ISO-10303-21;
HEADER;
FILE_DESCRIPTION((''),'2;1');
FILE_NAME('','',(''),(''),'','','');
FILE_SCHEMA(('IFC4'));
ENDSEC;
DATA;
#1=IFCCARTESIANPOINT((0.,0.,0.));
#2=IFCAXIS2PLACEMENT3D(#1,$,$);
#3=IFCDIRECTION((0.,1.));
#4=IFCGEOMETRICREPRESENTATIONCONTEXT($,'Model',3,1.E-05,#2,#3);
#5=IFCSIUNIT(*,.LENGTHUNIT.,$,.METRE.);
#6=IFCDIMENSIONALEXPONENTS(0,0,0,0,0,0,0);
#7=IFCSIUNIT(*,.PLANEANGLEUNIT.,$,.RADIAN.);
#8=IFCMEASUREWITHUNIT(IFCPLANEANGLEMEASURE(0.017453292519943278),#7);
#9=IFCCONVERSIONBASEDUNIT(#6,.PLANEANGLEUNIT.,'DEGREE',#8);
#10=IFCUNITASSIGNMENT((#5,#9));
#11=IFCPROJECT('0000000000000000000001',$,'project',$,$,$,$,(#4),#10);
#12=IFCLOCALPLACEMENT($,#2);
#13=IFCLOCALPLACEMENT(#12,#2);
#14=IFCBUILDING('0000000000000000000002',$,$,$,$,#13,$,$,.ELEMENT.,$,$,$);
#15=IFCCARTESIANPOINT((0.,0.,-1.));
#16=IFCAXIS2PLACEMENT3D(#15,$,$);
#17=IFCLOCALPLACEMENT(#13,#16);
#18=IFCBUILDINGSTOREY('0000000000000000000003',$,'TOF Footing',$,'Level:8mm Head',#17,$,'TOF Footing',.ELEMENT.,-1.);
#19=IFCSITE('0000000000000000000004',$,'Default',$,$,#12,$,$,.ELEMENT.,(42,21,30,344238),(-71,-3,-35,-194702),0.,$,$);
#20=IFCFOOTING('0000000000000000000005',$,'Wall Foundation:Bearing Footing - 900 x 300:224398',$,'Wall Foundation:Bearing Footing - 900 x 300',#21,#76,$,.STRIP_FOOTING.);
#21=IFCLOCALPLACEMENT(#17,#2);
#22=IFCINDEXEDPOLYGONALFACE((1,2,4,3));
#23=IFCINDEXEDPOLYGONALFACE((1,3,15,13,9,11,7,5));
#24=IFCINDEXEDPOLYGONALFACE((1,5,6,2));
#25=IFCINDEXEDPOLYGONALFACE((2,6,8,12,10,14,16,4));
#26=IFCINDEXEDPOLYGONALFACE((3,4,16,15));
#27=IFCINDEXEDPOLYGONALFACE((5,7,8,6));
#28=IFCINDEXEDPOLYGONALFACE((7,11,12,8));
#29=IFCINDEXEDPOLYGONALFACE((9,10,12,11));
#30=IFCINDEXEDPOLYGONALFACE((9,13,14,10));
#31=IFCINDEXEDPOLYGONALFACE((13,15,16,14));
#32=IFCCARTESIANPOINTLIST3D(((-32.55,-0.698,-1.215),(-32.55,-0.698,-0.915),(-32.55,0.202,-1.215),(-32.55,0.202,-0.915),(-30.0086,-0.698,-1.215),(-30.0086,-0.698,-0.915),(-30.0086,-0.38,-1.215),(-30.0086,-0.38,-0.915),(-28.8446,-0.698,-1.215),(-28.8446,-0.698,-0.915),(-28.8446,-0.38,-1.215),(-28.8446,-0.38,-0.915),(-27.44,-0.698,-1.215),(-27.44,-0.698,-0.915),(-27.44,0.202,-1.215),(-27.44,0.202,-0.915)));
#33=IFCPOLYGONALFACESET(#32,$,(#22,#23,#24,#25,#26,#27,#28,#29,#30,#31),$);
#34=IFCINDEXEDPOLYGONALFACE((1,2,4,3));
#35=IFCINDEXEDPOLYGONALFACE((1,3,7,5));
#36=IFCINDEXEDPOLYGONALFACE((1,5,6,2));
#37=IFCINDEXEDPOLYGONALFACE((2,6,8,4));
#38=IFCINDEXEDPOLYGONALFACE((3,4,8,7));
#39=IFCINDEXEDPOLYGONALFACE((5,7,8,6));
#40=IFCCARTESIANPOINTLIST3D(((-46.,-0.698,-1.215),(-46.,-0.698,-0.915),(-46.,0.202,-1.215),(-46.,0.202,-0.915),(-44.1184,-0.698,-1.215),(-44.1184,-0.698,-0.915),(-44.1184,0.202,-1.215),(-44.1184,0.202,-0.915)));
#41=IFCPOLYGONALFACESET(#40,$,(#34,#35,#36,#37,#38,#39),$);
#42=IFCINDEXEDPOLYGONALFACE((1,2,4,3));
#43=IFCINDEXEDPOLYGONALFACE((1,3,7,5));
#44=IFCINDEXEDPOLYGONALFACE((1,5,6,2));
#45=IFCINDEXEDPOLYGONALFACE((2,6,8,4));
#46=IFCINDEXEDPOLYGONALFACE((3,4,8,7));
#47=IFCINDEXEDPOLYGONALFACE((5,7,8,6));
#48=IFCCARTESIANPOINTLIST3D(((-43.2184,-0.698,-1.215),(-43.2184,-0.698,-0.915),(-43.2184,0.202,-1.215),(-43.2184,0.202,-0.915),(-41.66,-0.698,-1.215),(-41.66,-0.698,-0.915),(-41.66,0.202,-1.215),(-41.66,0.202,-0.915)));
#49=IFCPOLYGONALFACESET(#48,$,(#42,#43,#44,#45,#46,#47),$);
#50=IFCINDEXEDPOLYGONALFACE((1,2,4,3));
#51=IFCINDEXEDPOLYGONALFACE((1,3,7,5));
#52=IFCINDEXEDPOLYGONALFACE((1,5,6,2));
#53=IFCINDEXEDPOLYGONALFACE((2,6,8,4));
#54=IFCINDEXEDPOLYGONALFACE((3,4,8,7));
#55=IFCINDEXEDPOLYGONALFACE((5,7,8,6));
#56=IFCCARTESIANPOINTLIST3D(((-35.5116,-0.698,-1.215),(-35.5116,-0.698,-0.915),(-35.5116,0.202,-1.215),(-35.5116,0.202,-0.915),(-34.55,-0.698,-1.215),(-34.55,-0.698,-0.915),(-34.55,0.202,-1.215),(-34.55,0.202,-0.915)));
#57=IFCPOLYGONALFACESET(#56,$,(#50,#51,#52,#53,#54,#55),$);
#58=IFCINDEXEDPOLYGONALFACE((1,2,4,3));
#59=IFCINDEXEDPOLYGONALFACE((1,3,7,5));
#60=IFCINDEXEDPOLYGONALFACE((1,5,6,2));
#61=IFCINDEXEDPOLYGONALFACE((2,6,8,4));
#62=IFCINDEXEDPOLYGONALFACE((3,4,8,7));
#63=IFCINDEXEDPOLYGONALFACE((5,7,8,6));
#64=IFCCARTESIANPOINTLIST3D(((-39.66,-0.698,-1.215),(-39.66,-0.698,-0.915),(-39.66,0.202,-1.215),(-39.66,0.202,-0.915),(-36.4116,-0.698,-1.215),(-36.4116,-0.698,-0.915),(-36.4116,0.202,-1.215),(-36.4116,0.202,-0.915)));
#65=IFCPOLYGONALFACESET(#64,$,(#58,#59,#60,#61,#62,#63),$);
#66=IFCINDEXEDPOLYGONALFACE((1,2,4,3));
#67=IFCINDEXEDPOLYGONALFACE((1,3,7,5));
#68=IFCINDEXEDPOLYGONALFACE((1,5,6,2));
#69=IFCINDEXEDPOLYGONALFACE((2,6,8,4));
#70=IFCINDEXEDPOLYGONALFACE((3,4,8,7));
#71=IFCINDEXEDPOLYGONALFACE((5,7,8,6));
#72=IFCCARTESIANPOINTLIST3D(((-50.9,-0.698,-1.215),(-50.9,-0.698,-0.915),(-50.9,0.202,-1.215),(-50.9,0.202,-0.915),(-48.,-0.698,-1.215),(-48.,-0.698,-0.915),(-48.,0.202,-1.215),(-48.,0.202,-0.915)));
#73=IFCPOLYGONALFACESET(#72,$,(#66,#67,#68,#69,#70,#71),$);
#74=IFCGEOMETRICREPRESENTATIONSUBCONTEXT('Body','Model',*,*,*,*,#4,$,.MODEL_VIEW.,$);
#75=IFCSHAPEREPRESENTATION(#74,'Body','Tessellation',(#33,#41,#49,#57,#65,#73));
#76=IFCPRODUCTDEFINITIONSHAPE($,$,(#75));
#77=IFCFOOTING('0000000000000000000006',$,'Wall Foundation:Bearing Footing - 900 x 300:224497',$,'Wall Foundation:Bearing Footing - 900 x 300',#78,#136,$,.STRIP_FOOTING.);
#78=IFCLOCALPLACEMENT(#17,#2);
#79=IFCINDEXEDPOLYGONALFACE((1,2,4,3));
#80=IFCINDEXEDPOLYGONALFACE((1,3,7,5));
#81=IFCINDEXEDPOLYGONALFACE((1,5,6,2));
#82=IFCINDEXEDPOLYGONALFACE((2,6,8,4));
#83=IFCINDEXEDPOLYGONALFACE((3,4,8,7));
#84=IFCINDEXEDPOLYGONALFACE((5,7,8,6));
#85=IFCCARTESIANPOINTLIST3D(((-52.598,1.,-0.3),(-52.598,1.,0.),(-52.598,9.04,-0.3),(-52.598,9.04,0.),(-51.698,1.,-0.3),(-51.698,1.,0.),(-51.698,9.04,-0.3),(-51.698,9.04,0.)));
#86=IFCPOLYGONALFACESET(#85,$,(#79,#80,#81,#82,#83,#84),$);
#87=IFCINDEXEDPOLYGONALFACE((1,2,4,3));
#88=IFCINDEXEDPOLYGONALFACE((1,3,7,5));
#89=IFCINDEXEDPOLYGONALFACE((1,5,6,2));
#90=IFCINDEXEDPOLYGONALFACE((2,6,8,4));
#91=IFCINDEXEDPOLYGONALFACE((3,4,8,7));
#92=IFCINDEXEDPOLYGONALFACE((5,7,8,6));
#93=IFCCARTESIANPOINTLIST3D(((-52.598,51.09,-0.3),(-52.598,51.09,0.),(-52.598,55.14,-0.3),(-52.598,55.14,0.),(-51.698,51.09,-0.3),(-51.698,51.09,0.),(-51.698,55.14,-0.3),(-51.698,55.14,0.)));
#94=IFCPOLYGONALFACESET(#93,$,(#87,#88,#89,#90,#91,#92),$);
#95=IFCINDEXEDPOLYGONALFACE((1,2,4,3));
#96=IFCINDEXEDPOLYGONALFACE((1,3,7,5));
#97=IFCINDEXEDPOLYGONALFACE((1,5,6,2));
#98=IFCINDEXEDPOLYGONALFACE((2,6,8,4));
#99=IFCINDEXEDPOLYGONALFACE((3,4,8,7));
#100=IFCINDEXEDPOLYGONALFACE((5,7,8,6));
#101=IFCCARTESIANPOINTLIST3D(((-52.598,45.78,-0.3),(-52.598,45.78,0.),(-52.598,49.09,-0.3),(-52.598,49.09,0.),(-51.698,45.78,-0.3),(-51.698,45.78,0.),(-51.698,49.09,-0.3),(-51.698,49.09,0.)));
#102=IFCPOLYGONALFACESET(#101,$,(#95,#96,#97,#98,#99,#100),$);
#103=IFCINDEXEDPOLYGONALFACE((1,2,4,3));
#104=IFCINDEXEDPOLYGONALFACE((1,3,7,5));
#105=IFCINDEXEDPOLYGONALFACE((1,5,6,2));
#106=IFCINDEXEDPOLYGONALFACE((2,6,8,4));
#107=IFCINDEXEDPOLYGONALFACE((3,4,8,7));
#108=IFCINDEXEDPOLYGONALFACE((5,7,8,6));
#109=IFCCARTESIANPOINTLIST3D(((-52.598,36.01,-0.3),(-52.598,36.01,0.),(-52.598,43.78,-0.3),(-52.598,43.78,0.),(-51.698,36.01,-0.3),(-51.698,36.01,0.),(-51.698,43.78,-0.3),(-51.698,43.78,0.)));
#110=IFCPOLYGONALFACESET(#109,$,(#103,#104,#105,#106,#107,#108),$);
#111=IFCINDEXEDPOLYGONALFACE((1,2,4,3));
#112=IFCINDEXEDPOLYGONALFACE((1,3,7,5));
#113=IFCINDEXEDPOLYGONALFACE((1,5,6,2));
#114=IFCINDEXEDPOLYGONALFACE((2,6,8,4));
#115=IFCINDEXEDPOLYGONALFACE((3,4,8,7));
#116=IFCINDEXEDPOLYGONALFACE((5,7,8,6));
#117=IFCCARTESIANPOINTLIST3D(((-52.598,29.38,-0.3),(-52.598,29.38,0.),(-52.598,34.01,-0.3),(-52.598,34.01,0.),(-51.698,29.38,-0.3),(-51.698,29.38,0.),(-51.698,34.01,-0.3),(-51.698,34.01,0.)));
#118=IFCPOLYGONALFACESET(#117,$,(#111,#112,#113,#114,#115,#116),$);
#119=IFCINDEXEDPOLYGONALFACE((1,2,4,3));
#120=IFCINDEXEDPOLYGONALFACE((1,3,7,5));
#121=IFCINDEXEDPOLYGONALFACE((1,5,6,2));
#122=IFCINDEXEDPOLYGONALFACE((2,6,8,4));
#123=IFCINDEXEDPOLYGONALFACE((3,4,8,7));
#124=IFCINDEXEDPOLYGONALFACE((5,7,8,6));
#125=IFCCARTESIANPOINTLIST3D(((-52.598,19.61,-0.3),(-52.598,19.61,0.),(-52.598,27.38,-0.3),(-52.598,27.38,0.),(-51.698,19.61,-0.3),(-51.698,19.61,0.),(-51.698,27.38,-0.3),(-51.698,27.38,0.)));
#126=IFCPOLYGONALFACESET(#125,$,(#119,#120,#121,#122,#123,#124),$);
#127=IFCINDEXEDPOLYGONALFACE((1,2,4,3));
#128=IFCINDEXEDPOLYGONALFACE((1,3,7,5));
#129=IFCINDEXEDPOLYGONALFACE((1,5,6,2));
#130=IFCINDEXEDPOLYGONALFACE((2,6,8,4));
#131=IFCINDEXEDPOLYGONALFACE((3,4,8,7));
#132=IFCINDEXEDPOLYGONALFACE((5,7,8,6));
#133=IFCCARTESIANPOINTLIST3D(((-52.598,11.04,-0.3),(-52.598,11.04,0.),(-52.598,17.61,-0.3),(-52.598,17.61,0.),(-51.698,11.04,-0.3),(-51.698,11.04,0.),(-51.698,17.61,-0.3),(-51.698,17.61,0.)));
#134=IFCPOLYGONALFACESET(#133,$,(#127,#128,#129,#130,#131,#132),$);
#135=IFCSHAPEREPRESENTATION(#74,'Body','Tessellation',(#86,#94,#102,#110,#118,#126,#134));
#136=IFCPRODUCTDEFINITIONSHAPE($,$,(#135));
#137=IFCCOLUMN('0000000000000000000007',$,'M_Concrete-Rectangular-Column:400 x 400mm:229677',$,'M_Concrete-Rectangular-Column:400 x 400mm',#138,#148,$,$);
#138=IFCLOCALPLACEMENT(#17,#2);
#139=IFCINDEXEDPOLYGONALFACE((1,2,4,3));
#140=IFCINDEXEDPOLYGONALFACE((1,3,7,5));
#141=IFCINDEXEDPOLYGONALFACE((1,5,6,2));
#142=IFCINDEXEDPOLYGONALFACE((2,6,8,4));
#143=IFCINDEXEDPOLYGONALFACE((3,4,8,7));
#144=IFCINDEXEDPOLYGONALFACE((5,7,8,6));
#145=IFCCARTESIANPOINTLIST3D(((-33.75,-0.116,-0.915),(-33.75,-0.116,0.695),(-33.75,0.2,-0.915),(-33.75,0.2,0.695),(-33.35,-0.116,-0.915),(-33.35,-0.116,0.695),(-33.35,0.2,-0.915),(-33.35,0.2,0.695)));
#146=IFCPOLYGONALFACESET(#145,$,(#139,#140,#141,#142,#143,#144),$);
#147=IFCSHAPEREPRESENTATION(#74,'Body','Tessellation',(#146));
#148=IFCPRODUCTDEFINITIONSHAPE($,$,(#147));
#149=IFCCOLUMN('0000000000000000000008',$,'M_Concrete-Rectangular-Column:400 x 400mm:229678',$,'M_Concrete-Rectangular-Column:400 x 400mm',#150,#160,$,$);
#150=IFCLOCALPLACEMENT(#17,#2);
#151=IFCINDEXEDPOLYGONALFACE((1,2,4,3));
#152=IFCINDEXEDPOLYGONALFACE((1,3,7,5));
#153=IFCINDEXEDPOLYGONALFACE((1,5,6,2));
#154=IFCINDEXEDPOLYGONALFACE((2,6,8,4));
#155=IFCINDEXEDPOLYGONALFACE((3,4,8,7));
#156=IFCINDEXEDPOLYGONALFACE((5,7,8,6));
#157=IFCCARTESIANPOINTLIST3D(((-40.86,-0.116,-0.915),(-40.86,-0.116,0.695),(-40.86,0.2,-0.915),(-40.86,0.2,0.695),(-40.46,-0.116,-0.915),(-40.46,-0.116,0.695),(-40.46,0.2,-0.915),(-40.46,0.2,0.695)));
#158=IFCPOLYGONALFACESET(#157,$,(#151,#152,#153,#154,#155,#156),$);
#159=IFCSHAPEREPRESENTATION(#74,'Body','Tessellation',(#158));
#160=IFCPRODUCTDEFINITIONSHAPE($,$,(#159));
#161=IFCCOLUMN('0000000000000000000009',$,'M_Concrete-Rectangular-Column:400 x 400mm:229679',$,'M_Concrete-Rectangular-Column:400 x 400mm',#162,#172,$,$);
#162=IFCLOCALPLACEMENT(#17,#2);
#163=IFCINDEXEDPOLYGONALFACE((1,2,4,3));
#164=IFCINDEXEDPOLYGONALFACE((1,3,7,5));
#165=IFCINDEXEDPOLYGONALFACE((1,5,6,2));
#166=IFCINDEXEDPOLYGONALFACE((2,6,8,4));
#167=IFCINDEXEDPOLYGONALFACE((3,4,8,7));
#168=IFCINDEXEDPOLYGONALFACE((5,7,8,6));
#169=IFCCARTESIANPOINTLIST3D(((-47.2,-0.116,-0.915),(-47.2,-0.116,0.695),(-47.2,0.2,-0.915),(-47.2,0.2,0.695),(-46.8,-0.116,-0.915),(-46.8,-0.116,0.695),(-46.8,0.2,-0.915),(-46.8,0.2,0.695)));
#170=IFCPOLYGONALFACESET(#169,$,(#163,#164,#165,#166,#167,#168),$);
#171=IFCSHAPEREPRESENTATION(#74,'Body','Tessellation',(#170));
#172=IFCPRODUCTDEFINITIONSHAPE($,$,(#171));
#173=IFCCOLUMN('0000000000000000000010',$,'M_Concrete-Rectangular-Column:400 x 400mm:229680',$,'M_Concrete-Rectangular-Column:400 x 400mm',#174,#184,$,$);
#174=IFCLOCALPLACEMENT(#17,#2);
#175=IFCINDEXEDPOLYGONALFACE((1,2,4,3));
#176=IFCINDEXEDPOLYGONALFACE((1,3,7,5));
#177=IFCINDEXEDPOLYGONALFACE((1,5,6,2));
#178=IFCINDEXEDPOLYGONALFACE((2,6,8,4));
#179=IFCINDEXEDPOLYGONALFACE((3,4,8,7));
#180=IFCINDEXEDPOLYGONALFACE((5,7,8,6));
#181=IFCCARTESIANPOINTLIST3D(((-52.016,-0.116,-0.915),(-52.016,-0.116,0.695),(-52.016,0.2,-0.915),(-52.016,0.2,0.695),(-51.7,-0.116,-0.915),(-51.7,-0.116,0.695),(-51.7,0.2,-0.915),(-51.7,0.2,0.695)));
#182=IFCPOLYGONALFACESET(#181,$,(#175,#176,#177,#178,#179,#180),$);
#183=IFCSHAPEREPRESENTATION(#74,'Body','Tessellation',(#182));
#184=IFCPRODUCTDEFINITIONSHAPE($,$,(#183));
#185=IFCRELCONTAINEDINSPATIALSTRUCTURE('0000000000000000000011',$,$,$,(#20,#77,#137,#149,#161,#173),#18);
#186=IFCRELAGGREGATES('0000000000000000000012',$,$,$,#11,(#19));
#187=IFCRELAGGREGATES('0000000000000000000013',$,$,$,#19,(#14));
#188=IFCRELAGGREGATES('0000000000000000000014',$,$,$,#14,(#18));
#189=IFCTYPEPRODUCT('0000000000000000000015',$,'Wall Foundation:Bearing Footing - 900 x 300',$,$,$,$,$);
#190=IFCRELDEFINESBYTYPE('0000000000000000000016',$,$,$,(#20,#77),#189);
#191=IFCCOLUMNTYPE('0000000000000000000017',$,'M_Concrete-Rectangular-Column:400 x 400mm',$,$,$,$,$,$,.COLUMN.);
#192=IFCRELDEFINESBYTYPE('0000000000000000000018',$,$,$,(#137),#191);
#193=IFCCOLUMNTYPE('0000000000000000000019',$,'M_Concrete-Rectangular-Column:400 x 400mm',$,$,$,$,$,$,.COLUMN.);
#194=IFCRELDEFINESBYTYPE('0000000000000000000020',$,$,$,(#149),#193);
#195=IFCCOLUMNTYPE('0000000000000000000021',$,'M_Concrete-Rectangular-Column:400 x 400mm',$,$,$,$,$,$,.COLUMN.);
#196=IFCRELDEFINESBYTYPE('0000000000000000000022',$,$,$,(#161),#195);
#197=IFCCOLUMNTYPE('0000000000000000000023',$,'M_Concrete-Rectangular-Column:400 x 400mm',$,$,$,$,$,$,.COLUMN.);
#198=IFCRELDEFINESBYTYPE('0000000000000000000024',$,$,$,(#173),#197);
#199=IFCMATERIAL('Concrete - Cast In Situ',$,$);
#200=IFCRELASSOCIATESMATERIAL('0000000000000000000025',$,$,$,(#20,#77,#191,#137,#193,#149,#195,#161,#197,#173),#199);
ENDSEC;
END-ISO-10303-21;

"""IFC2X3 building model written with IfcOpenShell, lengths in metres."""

from ifc_helpers import new_model, entity, si_unit, converted_unit, direction, frame, frame_2d, origin, origin_2d_with_axis, place, context, subcontext, project, spatial, polyline, rectangle, outline, extrude, source, transform, mapped, material, type_object, type_shapes, element, save


model = new_model("IFC2X3")

# Units and contexts
model_context = context("Model", 3, precision=1e-05, world=origin(), true_north=direction((0.0, 1.0)))
body_context = subcontext(model_context, "Body", "Model", "MODEL_VIEW")
ifc_project = project(units=[si_unit("LENGTHUNIT", "METRE"), converted_unit("PLANEANGLEUNIT", "DEGREE", entity("IfcPlaneAngleMeasure", 0.017453292519943278), si_unit("PLANEANGLEUNIT", "RADIAN"), dimensions=[0, 0, 0, 0, 0, 0, 0])], contexts=[model_context])

# Site, building, storey
site_placement = place(None, origin())
site = spatial("IfcSite", under=ifc_project, at=site_placement, Name="Default", CompositionType="ELEMENT", RefLatitude=(42, 21, 30, 344238), RefLongitude=(-71, -3, -35, -194702), RefElevation=0.0)
building_placement = place(site_placement, origin())
building = spatial("IfcBuilding", under=site, at=building_placement, CompositionType="ELEMENT")
storey_placement = place(building_placement, frame((0.0, 0.0, -1.0)))
storey = spatial("IfcBuildingStorey", under=building, at=storey_placement, Name="TOF Footing", ObjectType="Level:8mm Head", LongName="TOF Footing", CompositionType="ELEMENT", Elevation=-1.0)

# Footings
ifc_material = material(Name="Concrete - Cast In Situ")
type_product_1 = type_object("IfcTypeProduct", Name="Wall Foundation:Bearing Footing - 900 x 300")
footing_1_placement = place(storey_placement, origin())
element("IfcFooting", 1, at=footing_1_placement, inside=storey, type_object=type_product_1, material=ifc_material, Name="Wall Foundation:Bearing Footing - 900 x 300:224398", ObjectType="Wall Foundation:Bearing Footing - 900 x 300", PredefinedType="STRIP_FOOTING", context=body_context, shape_type="SweptSolid", body=[
    extrude(outline(polyline([(-2.2708, -0.5955), (2.8392, -0.5955), (2.8392, 0.3045), (0.2978, 0.3045), (0.2978, -0.0135), (-0.8662, -0.0135), (-0.8662, 0.3045), (-2.2708, 0.3045), (-2.2708, -0.5955)])), frame((-29.7108, -0.3935, -1.215), z_axis=(0.0, 0.0, 1.0), x_axis=(-1.0, 0.0, 0.0)), (0.0, 0.0, 1.0), 0.3),
    extrude(rectangle(XDim=1.8816, YDim=0.9, at=frame_2d((0.0, 0.0), x_axis=(1.0, 0.0))), frame((-45.0592, -0.248, -1.215), z_axis=(0.0, 0.0, 1.0), x_axis=(-1.0, 0.0, 0.0)), (0.0, 0.0, 1.0), 0.3),
    extrude(rectangle(XDim=1.5584, YDim=0.9, at=origin_2d_with_axis()), frame((-42.4392, -0.248, -1.215)), (0.0, 0.0, 1.0), 0.3),
    extrude(rectangle(XDim=0.9616, YDim=0.9, at=frame_2d((0.0, 0.0), x_axis=(1.0, 0.0))), frame((-35.0308, -0.248, -1.215)), (0.0, 0.0, 1.0), 0.3),
    extrude(rectangle(XDim=3.2484, YDim=0.9, at=frame_2d((0.0, 0.0), x_axis=(1.0, 0.0))), frame((-38.0358, -0.248, -1.215), z_axis=(0.0, 0.0, 1.0), x_axis=(-1.0, 0.0, 0.0)), (0.0, 0.0, 1.0), 0.3),
    extrude(rectangle(XDim=2.9, YDim=0.9, at=frame_2d((0.0, 0.0), x_axis=(1.0, 0.0))), frame((-49.45, -0.248, -1.215)), (0.0, 0.0, 1.0), 0.3),
])
footing_2_placement = place(storey_placement, origin())
element("IfcFooting", 2, at=footing_2_placement, inside=storey, type_object=type_product_1, material=ifc_material, Name="Wall Foundation:Bearing Footing - 900 x 300:224497", ObjectType="Wall Foundation:Bearing Footing - 900 x 300", PredefinedType="STRIP_FOOTING", context=body_context, shape_type="SweptSolid", body=[
    extrude(rectangle(XDim=8.04, YDim=0.9, at=frame_2d((0.0, 0.0), x_axis=(1.0, 0.0))), frame((-52.148, 5.02, -0.3), z_axis=(0.0, 0.0, 1.0), x_axis=(0.0, 1.0, 0.0)), (0.0, 0.0, 1.0), 0.3),
    extrude(rectangle(XDim=4.05, YDim=0.9, at=frame_2d((0.0, 0.0), x_axis=(1.0, 0.0))), frame((-52.148, 53.115, -0.3), z_axis=(0.0, 0.0, 1.0), x_axis=(0.0, -1.0, 0.0)), (0.0, 0.0, 1.0), 0.3),
    extrude(rectangle(XDim=3.31, YDim=0.9, at=frame_2d((0.0, 0.0), x_axis=(1.0, 0.0))), frame((-52.148, 47.435, -0.3), z_axis=(0.0, 0.0, 1.0), x_axis=(0.0, -1.0, 0.0)), (0.0, 0.0, 1.0), 0.3),
    extrude(rectangle(XDim=7.77, YDim=0.9, at=frame_2d((0.0, 0.0), x_axis=(1.0, 0.0))), frame((-52.148, 39.895, -0.3), z_axis=(0.0, 0.0, 1.0), x_axis=(0.0, -1.0, 0.0)), (0.0, 0.0, 1.0), 0.3),
    extrude(rectangle(XDim=4.63, YDim=0.9, at=frame_2d((0.0, 0.0), x_axis=(1.0, 0.0))), frame((-52.148, 31.695, -0.3), z_axis=(0.0, 0.0, 1.0), x_axis=(0.0, -1.0, 0.0)), (0.0, 0.0, 1.0), 0.3),
    extrude(rectangle(XDim=7.77, YDim=0.9, at=frame_2d((0.0, 0.0), x_axis=(1.0, 0.0))), frame((-52.148, 23.495, -0.3), z_axis=(0.0, 0.0, 1.0), x_axis=(0.0, -1.0, 0.0)), (0.0, 0.0, 1.0), 0.3),
    extrude(rectangle(XDim=6.57, YDim=0.9, at=frame_2d((0.0, 0.0), x_axis=(1.0, 0.0))), frame((-52.148, 14.325, -0.3), z_axis=(0.0, 0.0, 1.0), x_axis=(0.0, -1.0, 0.0)), (0.0, 0.0, 1.0), 0.3),
])

# Columns
column_type_1 = type_object("IfcColumnType", Name="M_Concrete-Rectangular-Column:400 x 400mm", PredefinedType="COLUMN", material=ifc_material)
shared_shape_1 = source(origin(), body_context, "Body", "SweptSolid", [
    extrude(rectangle(XDim=0.316, YDim=0.4, at=frame_2d((0.0, 0.0), x_axis=(1.0, 0.0))), frame((-33.55, 0.042, -1.915), z_axis=(0.0, 0.0, 1.0), x_axis=(0.0, -1.0, 0.0)), (0.0, 0.0, 1.0), 1.61),
])
type_shapes(column_type_1, [shared_shape_1])
column_1_placement = place(storey_placement, frame((0.0, 0.0, 1.0)))
element("IfcColumn", 3, at=column_1_placement, inside=storey, type_object=column_type_1, material=ifc_material, Name="M_Concrete-Rectangular-Column:400 x 400mm:229677", ObjectType="M_Concrete-Rectangular-Column:400 x 400mm", context=body_context, shape_type="MappedRepresentation", body=[
    mapped(shared_shape_1, transform((0.0, 0.0, 0.0), scale=1.0)),
])
column_type_2 = type_object("IfcColumnType", Name="M_Concrete-Rectangular-Column:400 x 400mm", PredefinedType="COLUMN", material=ifc_material)
shared_shape_2 = source(origin(), body_context, "Body", "SweptSolid", [
    extrude(rectangle(XDim=0.316, YDim=0.4, at=frame_2d((0.0, 0.0), x_axis=(1.0, 0.0))), frame((-40.66, 0.042, -1.915), z_axis=(0.0, 0.0, 1.0), x_axis=(0.0, -1.0, 0.0)), (0.0, 0.0, 1.0), 1.61),
])
type_shapes(column_type_2, [shared_shape_2])
column_2_placement = place(storey_placement, frame((0.0, 0.0, 1.0)))
element("IfcColumn", 4, at=column_2_placement, inside=storey, type_object=column_type_2, material=ifc_material, Name="M_Concrete-Rectangular-Column:400 x 400mm:229678", ObjectType="M_Concrete-Rectangular-Column:400 x 400mm", context=body_context, shape_type="MappedRepresentation", body=[
    mapped(shared_shape_2, transform((0.0, 0.0, 0.0), scale=1.0)),
])
column_type_3 = type_object("IfcColumnType", Name="M_Concrete-Rectangular-Column:400 x 400mm", PredefinedType="COLUMN", material=ifc_material)
shared_shape_3 = source(origin(), body_context, "Body", "SweptSolid", [
    extrude(rectangle(XDim=0.316, YDim=0.4, at=frame_2d((0.0, 0.0), x_axis=(1.0, 0.0))), frame((-47.0, 0.042, -1.915), z_axis=(0.0, 0.0, 1.0), x_axis=(0.0, -1.0, 0.0)), (0.0, 0.0, 1.0), 1.61),
])
type_shapes(column_type_3, [shared_shape_3])
column_3_placement = place(storey_placement, frame((0.0, 0.0, 1.0)))
element("IfcColumn", 5, at=column_3_placement, inside=storey, type_object=column_type_3, material=ifc_material, Name="M_Concrete-Rectangular-Column:400 x 400mm:229679", ObjectType="M_Concrete-Rectangular-Column:400 x 400mm", context=body_context, shape_type="MappedRepresentation", body=[
    mapped(shared_shape_3, transform((0.0, 0.0, 0.0), scale=1.0)),
])
column_type_4 = type_object("IfcColumnType", Name="M_Concrete-Rectangular-Column:400 x 400mm", PredefinedType="COLUMN", material=ifc_material)
shared_shape_4 = source(origin(), body_context, "Body", "SweptSolid", [
    extrude(rectangle(XDim=0.316, YDim=0.316, at=frame_2d((0.0, 0.0), x_axis=(1.0, 0.0))), frame((-51.858, 0.042, -1.915), z_axis=(0.0, 0.0, 1.0), x_axis=(0.0, -1.0, 0.0)), (0.0, 0.0, 1.0), 1.61),
])
type_shapes(column_type_4, [shared_shape_4])
column_4_placement = place(storey_placement, frame((0.0, 0.0, 1.0)))
element("IfcColumn", 6, at=column_4_placement, inside=storey, type_object=column_type_4, material=ifc_material, Name="M_Concrete-Rectangular-Column:400 x 400mm:229680", ObjectType="M_Concrete-Rectangular-Column:400 x 400mm", context=body_context, shape_type="MappedRepresentation", body=[
    mapped(shared_shape_4, transform((0.0, 0.0, 0.0), scale=1.0)),
])

save(model, "model.ifc")
